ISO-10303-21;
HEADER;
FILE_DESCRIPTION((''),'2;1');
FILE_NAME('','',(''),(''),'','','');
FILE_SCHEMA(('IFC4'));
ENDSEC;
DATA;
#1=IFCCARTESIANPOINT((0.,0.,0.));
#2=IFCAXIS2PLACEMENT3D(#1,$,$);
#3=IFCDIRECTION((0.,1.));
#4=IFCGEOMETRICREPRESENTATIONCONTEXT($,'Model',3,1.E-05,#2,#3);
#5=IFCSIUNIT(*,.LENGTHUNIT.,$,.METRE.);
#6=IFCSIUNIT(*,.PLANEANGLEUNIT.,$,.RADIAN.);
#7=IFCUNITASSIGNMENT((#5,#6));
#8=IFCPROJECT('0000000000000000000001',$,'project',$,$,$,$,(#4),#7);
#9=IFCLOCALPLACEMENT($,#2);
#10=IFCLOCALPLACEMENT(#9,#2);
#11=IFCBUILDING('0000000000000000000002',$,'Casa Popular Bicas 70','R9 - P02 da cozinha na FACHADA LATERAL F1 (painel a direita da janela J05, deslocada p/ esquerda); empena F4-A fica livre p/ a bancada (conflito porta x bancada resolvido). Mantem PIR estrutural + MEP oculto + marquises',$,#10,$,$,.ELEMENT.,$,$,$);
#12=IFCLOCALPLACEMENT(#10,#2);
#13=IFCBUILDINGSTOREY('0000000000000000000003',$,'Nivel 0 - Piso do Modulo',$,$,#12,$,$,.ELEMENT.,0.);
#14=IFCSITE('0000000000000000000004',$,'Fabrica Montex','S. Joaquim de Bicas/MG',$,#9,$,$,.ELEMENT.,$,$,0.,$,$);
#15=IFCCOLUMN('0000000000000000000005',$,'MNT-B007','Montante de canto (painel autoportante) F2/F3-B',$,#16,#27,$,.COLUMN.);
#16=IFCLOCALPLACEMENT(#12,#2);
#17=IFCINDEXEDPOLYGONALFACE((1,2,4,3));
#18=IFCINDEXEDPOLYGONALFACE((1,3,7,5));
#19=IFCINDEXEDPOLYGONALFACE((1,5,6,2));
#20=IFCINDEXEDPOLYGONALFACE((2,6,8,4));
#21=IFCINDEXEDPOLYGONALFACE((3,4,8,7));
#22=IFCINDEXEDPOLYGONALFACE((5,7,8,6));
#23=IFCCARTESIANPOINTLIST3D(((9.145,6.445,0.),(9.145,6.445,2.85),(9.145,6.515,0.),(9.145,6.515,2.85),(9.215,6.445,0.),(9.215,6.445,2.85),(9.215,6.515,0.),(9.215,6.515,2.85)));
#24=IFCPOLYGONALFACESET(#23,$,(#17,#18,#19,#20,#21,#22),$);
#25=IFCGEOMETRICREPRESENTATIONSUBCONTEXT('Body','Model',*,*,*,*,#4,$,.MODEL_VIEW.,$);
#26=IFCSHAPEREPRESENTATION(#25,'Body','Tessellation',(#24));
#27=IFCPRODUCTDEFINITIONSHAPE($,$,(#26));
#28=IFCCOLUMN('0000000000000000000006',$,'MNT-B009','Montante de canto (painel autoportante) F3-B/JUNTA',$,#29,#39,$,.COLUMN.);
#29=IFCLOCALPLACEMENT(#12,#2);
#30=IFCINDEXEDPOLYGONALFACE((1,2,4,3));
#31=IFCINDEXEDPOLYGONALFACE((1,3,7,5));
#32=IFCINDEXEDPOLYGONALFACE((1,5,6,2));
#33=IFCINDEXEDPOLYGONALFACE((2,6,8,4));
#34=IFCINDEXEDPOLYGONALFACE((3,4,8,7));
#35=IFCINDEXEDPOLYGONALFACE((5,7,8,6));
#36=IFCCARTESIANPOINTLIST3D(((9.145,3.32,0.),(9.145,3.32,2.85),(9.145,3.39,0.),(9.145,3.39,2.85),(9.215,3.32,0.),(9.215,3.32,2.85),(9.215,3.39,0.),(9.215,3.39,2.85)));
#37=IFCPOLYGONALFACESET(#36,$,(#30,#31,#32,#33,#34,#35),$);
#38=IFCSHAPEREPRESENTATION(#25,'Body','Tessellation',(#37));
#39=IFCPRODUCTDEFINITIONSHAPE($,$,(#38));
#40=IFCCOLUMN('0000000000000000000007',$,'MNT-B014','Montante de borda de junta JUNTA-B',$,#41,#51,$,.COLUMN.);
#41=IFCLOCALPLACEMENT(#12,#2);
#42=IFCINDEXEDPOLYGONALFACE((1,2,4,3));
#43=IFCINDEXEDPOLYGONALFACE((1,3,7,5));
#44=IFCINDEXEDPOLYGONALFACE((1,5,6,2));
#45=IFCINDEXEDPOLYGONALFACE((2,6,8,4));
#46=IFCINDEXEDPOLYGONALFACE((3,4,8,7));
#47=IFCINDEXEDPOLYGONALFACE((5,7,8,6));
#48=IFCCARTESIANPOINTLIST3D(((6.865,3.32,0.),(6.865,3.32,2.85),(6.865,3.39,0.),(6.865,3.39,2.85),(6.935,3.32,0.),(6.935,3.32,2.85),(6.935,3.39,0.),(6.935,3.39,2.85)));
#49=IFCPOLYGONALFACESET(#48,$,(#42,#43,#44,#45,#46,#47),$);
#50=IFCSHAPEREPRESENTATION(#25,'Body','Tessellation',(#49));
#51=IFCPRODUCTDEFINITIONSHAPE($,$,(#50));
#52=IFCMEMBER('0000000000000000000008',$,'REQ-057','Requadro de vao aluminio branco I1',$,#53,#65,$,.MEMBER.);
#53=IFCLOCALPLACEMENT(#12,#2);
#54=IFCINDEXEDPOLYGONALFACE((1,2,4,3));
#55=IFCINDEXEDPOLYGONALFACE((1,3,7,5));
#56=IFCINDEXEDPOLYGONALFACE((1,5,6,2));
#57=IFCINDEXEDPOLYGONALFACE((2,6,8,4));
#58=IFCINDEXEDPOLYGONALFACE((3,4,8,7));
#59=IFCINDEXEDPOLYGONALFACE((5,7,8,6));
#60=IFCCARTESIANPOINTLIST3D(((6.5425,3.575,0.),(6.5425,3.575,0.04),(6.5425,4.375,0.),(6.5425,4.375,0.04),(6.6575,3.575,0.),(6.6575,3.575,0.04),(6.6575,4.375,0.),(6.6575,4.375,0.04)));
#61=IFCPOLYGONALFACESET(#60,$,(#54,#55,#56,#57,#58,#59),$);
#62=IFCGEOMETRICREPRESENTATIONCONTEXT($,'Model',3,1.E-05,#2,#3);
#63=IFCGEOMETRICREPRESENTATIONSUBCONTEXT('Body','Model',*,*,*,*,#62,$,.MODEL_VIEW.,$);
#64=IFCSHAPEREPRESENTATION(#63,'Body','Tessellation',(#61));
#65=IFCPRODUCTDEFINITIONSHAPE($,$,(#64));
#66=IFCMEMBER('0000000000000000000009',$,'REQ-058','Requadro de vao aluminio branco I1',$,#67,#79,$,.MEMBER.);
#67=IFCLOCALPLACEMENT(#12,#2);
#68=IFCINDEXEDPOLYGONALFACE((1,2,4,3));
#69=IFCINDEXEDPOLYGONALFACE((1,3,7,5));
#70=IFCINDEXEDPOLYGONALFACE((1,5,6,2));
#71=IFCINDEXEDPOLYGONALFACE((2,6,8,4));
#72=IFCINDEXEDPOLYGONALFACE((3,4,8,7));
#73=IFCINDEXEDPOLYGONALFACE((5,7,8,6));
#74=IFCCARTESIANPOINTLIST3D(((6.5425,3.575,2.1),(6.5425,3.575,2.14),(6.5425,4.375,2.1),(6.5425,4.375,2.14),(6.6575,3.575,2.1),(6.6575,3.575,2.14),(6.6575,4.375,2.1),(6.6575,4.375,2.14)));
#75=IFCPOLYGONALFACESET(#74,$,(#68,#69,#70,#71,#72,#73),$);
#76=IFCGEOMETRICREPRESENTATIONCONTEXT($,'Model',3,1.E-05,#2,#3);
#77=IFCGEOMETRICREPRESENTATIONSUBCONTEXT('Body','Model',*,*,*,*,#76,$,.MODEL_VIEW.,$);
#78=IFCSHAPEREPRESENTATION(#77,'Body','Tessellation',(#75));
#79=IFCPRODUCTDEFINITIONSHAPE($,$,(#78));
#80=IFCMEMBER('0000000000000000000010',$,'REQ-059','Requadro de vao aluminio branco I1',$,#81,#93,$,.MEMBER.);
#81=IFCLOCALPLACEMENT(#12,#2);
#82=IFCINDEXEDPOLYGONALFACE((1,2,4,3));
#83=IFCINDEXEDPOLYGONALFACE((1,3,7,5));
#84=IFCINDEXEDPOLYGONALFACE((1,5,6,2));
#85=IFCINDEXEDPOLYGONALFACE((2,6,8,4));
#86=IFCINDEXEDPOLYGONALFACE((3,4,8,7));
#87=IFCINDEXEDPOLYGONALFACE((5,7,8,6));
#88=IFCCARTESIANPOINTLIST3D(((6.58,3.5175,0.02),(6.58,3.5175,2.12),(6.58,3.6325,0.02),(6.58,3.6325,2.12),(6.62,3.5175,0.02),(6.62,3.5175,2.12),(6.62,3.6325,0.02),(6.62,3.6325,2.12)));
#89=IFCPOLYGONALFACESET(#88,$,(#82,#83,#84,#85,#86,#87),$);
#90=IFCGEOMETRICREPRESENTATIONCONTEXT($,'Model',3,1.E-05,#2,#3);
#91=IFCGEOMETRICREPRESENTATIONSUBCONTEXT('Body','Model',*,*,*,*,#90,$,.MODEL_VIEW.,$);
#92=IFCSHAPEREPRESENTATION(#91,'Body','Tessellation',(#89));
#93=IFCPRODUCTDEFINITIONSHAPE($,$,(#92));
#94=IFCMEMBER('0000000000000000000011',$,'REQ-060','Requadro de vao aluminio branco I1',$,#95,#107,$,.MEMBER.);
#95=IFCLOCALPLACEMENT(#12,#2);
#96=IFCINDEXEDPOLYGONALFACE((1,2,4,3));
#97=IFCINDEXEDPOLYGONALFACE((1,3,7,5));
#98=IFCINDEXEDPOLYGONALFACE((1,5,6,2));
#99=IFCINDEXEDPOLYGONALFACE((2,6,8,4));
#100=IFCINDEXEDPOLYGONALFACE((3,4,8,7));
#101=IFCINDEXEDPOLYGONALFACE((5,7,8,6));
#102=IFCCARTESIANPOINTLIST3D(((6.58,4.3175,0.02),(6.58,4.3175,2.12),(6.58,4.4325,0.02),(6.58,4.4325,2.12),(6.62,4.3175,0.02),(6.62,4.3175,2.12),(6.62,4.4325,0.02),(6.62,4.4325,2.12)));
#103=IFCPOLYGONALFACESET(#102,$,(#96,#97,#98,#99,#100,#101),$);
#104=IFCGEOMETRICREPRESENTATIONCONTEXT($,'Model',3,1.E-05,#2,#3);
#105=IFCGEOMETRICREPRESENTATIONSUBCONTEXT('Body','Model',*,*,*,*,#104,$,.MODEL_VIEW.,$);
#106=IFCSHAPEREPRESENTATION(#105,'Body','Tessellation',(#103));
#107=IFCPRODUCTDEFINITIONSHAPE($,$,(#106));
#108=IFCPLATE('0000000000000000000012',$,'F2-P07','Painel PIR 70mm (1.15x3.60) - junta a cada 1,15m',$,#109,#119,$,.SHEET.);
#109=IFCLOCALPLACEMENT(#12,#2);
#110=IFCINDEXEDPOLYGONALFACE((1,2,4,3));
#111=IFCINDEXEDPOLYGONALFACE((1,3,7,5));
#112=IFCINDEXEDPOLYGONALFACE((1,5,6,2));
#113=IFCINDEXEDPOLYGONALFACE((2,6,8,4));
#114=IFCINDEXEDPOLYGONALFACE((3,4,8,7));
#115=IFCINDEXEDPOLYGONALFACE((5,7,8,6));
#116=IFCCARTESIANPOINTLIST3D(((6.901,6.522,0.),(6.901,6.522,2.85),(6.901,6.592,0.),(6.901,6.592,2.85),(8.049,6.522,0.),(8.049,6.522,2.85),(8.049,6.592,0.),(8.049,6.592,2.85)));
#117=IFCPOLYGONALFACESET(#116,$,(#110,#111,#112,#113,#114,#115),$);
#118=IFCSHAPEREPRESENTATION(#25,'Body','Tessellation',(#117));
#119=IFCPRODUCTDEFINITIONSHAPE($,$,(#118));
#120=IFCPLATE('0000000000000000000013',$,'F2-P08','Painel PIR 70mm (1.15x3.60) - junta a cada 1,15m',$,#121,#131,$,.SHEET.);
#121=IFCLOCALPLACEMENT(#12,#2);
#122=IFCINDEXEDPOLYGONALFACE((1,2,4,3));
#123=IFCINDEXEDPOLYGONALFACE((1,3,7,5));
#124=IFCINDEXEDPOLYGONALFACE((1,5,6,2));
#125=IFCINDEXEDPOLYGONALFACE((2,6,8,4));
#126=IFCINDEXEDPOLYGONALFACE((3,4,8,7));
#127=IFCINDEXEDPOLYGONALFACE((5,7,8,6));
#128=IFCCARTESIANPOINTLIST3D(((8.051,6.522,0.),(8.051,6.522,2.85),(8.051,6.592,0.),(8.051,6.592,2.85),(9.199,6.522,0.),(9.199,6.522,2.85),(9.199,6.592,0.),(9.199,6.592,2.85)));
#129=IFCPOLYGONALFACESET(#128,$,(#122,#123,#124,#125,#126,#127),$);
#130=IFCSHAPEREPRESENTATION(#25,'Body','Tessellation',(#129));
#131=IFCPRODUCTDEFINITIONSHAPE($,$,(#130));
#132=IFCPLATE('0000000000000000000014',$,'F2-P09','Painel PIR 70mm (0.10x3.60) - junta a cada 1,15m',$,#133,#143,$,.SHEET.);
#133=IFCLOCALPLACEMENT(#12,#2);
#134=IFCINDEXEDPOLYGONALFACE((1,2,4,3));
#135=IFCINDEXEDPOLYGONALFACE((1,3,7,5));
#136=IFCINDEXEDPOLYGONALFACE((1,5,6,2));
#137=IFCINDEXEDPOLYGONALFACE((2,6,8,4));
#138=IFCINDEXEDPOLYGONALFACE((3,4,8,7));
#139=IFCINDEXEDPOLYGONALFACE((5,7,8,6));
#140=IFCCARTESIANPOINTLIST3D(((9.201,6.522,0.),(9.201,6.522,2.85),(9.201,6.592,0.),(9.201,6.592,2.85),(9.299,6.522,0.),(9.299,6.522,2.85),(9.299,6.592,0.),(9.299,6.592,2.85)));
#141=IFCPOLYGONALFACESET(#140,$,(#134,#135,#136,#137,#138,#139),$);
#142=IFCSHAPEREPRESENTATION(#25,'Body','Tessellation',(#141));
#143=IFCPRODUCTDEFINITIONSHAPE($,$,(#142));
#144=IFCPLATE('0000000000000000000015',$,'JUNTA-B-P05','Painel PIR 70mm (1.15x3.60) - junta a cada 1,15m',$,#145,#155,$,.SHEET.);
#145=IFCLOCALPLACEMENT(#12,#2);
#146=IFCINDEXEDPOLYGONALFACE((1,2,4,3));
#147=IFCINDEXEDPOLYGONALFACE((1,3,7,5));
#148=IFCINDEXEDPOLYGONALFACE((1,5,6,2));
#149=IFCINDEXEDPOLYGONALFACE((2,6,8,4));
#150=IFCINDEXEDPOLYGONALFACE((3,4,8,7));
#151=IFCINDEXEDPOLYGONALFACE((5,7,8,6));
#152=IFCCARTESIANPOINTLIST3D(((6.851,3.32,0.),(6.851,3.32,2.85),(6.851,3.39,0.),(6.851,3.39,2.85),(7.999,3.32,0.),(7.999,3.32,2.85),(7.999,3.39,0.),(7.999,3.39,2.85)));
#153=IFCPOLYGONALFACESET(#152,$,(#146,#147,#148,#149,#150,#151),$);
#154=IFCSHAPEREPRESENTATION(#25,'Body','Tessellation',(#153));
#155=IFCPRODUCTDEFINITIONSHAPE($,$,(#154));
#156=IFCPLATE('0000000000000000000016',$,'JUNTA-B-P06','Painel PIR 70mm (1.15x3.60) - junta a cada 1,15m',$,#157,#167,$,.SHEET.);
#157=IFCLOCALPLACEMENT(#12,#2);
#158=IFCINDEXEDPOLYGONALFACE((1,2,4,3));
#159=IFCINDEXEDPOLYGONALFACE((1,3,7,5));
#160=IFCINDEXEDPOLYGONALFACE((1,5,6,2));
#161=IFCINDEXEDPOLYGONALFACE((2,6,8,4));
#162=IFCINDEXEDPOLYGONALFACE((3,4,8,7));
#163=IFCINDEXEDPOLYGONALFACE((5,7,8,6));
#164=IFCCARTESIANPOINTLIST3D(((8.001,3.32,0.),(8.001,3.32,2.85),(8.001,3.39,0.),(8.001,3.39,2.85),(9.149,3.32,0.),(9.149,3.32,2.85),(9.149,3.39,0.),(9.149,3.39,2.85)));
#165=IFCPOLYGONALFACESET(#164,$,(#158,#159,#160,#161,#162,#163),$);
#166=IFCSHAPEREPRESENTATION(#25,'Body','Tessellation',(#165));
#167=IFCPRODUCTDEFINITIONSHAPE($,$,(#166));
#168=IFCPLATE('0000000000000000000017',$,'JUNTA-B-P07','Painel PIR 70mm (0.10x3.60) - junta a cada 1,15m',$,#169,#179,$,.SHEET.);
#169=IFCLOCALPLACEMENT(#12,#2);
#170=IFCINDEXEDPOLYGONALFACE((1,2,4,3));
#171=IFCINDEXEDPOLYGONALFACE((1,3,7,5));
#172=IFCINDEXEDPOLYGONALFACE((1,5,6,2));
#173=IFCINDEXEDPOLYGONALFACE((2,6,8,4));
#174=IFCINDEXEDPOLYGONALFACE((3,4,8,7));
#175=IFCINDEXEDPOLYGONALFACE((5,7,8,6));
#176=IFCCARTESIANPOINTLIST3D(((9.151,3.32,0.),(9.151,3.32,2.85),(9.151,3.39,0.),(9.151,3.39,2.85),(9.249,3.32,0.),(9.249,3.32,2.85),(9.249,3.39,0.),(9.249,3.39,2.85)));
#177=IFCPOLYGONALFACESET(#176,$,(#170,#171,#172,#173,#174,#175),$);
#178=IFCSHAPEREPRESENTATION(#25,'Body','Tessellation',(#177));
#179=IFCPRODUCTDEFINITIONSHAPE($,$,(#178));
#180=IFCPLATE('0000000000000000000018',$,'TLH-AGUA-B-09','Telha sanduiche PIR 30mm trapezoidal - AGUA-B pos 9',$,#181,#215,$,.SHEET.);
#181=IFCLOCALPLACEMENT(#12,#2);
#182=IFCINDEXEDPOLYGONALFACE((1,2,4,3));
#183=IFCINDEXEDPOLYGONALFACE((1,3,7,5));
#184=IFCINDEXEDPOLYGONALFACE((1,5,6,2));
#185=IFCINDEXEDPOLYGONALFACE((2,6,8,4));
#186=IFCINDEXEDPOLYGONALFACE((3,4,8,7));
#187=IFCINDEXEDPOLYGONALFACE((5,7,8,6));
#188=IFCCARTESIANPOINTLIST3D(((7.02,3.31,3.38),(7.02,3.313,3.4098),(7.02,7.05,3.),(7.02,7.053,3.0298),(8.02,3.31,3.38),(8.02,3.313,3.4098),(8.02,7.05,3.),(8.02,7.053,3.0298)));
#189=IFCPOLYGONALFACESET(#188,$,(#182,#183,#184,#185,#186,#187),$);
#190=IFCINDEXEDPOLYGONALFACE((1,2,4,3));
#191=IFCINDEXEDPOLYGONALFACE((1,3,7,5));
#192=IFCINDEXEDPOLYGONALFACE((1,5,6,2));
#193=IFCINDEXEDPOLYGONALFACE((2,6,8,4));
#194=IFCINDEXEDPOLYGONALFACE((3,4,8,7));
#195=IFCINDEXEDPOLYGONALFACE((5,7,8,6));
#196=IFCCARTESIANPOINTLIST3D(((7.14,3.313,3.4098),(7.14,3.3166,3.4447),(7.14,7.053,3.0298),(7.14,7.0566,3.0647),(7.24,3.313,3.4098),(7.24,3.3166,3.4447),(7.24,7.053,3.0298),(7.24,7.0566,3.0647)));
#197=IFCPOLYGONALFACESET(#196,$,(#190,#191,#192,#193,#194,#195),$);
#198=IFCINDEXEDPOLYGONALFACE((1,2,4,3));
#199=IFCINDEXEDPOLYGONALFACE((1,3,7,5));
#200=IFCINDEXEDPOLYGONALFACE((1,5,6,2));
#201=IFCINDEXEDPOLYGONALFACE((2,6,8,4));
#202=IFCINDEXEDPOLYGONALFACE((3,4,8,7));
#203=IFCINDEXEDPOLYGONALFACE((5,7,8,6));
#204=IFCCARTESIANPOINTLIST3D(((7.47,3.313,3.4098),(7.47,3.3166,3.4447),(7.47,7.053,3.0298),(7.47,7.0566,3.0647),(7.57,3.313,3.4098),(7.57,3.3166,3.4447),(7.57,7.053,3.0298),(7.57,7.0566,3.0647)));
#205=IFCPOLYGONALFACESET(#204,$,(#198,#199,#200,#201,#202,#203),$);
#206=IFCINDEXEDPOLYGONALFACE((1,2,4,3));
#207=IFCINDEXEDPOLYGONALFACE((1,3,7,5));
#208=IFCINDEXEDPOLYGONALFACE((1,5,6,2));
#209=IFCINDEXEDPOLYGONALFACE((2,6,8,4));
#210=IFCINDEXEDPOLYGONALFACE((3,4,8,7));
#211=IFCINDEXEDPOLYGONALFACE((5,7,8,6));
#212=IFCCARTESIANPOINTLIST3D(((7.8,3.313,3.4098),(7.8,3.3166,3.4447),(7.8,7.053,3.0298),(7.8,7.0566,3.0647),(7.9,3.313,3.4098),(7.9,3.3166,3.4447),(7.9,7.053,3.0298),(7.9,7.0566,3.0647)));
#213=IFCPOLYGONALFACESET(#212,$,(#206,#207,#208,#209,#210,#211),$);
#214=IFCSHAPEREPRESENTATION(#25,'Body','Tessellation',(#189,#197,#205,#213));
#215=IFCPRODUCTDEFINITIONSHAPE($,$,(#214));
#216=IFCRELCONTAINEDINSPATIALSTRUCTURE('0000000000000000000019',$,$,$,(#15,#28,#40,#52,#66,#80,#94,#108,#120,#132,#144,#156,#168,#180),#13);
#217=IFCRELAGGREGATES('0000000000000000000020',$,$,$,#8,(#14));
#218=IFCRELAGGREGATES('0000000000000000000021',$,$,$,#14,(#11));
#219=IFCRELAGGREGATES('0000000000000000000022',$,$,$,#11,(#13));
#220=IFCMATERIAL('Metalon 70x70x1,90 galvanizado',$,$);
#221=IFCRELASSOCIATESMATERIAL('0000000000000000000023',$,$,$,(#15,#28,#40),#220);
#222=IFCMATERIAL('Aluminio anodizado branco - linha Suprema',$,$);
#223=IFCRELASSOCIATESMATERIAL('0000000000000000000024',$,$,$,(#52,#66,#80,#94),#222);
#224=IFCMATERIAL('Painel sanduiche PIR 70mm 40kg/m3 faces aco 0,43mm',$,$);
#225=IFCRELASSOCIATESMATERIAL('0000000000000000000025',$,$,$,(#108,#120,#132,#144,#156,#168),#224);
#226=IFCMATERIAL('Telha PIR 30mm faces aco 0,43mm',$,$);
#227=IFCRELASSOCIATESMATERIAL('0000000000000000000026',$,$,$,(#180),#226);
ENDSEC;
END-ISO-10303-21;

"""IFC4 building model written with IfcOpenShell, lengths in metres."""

from ifc_helpers import new_model, si_unit, direction, frame, frame_2d, origin, origin_2d, place, context, subcontext, project, spatial, rectangle, extrude, material, element, save


model = new_model("IFC4")

# Units and contexts
model_context_1 = context("Model", 3, precision=1e-05, world=origin(), true_north=direction((0.0, 1.0)))
model_context_2 = context("Model", 3, precision=1e-05, world=origin(), true_north=direction((0.0, 1.0)))
model_context_3 = context("Model", 3, precision=1e-05, world=origin(), true_north=direction((0.0, 1.0)))
model_context_4 = context("Model", 3, precision=1e-05, world=origin(), true_north=direction((0.0, 1.0)))
model_context_5 = context("Model", 3, precision=1e-05, world=origin(), true_north=direction((0.0, 1.0)))
body_context_1 = subcontext(model_context_1, "Body", "Model", "MODEL_VIEW")
body_context_2 = subcontext(model_context_2, "Body", "Model", "MODEL_VIEW")
body_context_3 = subcontext(model_context_3, "Body", "Model", "MODEL_VIEW")
body_context_4 = subcontext(model_context_4, "Body", "Model", "MODEL_VIEW")
body_context_5 = subcontext(model_context_5, "Body", "Model", "MODEL_VIEW")
ifc_project = project(units=[si_unit("LENGTHUNIT", "METRE"), si_unit("PLANEANGLEUNIT", "RADIAN")], contexts=[model_context_1])

# Site, building, storey
site_placement = place(None, origin())
site = spatial("IfcSite", under=ifc_project, at=site_placement, Name="Fabrica Montex", Description="S. Joaquim de Bicas/MG", CompositionType="ELEMENT", RefElevation=0.0)
building_placement = place(site_placement, origin())
building = spatial("IfcBuilding", under=site, at=building_placement, Name="Casa Popular Bicas 70", Description="R9 - P02 da cozinha na FACHADA LATERAL F1 (painel a direita da janela J05, deslocada p/ esquerda); empena F4-A fica livre p/ a bancada (conflito porta x bancada resolvido). Mantem PIR estrutural + MEP oculto + marquises", CompositionType="ELEMENT")
storey_placement = place(building_placement, origin())
storey = spatial("IfcBuildingStorey", under=building, at=storey_placement, Name="Nivel 0 - Piso do Modulo", CompositionType="ELEMENT", Elevation=0.0)

# Columns
ifc_material_1 = material(Name="Metalon 70x70x1,90 galvanizado")
for number, where, name, description in (
    (1, (9.18, 6.48, 0.0), "MNT-B007", "Montante de canto (painel autoportante) F2/F3-B"),
    (2, (9.18, 3.355, 0.0), "MNT-B009", "Montante de canto (painel autoportante) F3-B/JUNTA"),
    (3, (6.9, 3.355, 0.0), "MNT-B014", "Montante de borda de junta JUNTA-B"),
):
    element("IfcColumn", number, at=place(storey_placement, frame(where)), inside=storey, material=ifc_material_1, Name=name, Description=description, PredefinedType="COLUMN", context=body_context_1, shape_type="SweptSolid", body=[
        extrude(rectangle(XDim=0.07, YDim=0.07, at=origin_2d()), origin(), (0.0, 0.0, 1.0), 2.85),
    ])

# Members
ifc_material_2 = material(Name="Aluminio anodizado branco - linha Suprema")
placement_1 = place(None, origin())
placement_2 = place(placement_1, origin())
placement_3 = place(placement_2, origin())
member_1_placement = place(placement_3, frame((6.6, 3.575, 0.02), z_axis=(0.0, 1.0, 0.0), x_axis=(0.0, 0.0, 1.0)))
element("IfcMember", 4, at=member_1_placement, inside=storey, material=ifc_material_2, Name="REQ-057", Description="Requadro de vao aluminio branco I1", PredefinedType="MEMBER", context=body_context_2, shape_type="SweptSolid", body=[
    extrude(rectangle(XDim=0.04, YDim=0.115, at=origin_2d()), origin(), (0.0, 0.0, 1.0), 0.8),
])
placement_4 = place(None, origin())
placement_5 = place(placement_4, origin())
placement_6 = place(placement_5, origin())
member_2_placement = place(placement_6, frame((6.6, 3.575, 2.12), z_axis=(0.0, 1.0, 0.0), x_axis=(0.0, 0.0, 1.0)))
element("IfcMember", 5, at=member_2_placement, inside=storey, material=ifc_material_2, Name="REQ-058", Description="Requadro de vao aluminio branco I1", PredefinedType="MEMBER", context=body_context_3, shape_type="SweptSolid", body=[
    extrude(rectangle(XDim=0.04, YDim=0.115, at=origin_2d()), origin(), (0.0, 0.0, 1.0), 0.8),
])
placement_7 = place(None, origin())
placement_8 = place(placement_7, origin())
placement_9 = place(placement_8, origin())
member_3_placement = place(placement_9, frame((6.6, 3.575, 0.02), z_axis=(0.0, 0.0, 1.0), x_axis=(1.0, 0.0, 0.0)))
element("IfcMember", 6, at=member_3_placement, inside=storey, material=ifc_material_2, Name="REQ-059", Description="Requadro de vao aluminio branco I1", PredefinedType="MEMBER", context=body_context_4, shape_type="SweptSolid", body=[
    extrude(rectangle(XDim=0.04, YDim=0.115, at=origin_2d()), origin(), (0.0, 0.0, 1.0), 2.1),
])
placement_10 = place(None, origin())
placement_11 = place(placement_10, origin())
placement_12 = place(placement_11, origin())
member_4_placement = place(placement_12, frame((6.6, 4.375, 0.02), z_axis=(0.0, 0.0, 1.0), x_axis=(1.0, 0.0, 0.0)))
element("IfcMember", 7, at=member_4_placement, inside=storey, material=ifc_material_2, Name="REQ-060", Description="Requadro de vao aluminio branco I1", PredefinedType="MEMBER", context=body_context_5, shape_type="SweptSolid", body=[
    extrude(rectangle(XDim=0.04, YDim=0.115, at=origin_2d()), origin(), (0.0, 0.0, 1.0), 2.1),
])

# Plates
ifc_material_3 = material(Name="Painel sanduiche PIR 70mm 40kg/m3 faces aco 0,43mm")
for number, where, x_axis, name in (
    (8, (6.901, 6.557, 0.0), (1.0, 0.0, 0.0), "F2-P07"),
    (9, (8.051, 6.557, 0.0), (1.0, 0.0, 0.0), "F2-P08"),
):
    element("IfcPlate", number, at=place(storey_placement, frame(where, x_axis=x_axis)), inside=storey, material=ifc_material_3, Name=name, Description="Painel PIR 70mm (1.15x3.60) - junta a cada 1,15m", PredefinedType="SHEET", context=body_context_1, shape_type="SweptSolid", body=[
        extrude(rectangle(XDim=1.148, YDim=0.07, at=frame_2d((0.574, 0.0))), origin(), (0.0, 0.0, 1.0), 2.85),
    ])
plate_1_placement = place(storey_placement, frame((9.201, 6.557, 0.0), x_axis=(1.0, 0.0, 0.0)))
element("IfcPlate", 10, at=plate_1_placement, inside=storey, material=ifc_material_3, Name="F2-P09", Description="Painel PIR 70mm (0.10x3.60) - junta a cada 1,15m", PredefinedType="SHEET", context=body_context_1, shape_type="SweptSolid", body=[
    extrude(rectangle(XDim=0.098, YDim=0.07, at=frame_2d((0.049, 0.0))), origin(), (0.0, 0.0, 1.0), 2.85),
])
for number, where, x_axis, name in (
    (11, (6.851, 3.355, 0.0), (1.0, 0.0, 0.0), "JUNTA-B-P05"),
    (12, (8.001, 3.355, 0.0), (1.0, 0.0, 0.0), "JUNTA-B-P06"),
):
    element("IfcPlate", number, at=place(storey_placement, frame(where, x_axis=x_axis)), inside=storey, material=ifc_material_3, Name=name, Description="Painel PIR 70mm (1.15x3.60) - junta a cada 1,15m", PredefinedType="SHEET", context=body_context_1, shape_type="SweptSolid", body=[
        extrude(rectangle(XDim=1.148, YDim=0.07, at=frame_2d((0.574, 0.0))), origin(), (0.0, 0.0, 1.0), 2.85),
    ])
plate_2_placement = place(storey_placement, frame((9.151, 3.355, 0.0), x_axis=(1.0, 0.0, 0.0)))
element("IfcPlate", 13, at=plate_2_placement, inside=storey, material=ifc_material_3, Name="JUNTA-B-P07", Description="Painel PIR 70mm (0.10x3.60) - junta a cada 1,15m", PredefinedType="SHEET", context=body_context_1, shape_type="SweptSolid", body=[
    extrude(rectangle(XDim=0.098, YDim=0.07, at=frame_2d((0.049, 0.0))), origin(), (0.0, 0.0, 1.0), 2.85),
])
ifc_material_4 = material(Name="Telha PIR 30mm faces aco 0,43mm")
for number, where, z_axis, x_axis, name in (
    (14, (7.02, 3.31, 3.38), (0.0, 0.101084, 0.994878), (1.0, 0.0, 0.0), "TLH-AGUA-B-09"),
):
    element("IfcPlate", number, at=place(storey_placement, frame(where, z_axis=z_axis, x_axis=x_axis)), inside=storey, material=ifc_material_4, Name=name, Description="Telha sanduiche PIR 30mm trapezoidal - AGUA-B pos 9", PredefinedType="SHEET", context=body_context_1, shape_type="SweptSolid", body=[
        extrude(rectangle(XDim=1.0, YDim=3.7593, at=frame_2d((0.5, 1.8796))), origin(), (0.0, 0.0, 1.0), 0.03),
        extrude(rectangle(XDim=0.1, YDim=3.7593, at=frame_2d((0.17, 1.8796))), frame((0.0, 0.0, 0.03)), (0.0, 0.0, 1.0), 0.035),
        extrude(rectangle(XDim=0.1, YDim=3.7593, at=frame_2d((0.5, 1.8796))), frame((0.0, 0.0, 0.03)), (0.0, 0.0, 1.0), 0.035),
        extrude(rectangle(XDim=0.1, YDim=3.7593, at=frame_2d((0.83, 1.8796))), frame((0.0, 0.0, 0.03)), (0.0, 0.0, 1.0), 0.035),
    ])

save(model, "model.ifc")
